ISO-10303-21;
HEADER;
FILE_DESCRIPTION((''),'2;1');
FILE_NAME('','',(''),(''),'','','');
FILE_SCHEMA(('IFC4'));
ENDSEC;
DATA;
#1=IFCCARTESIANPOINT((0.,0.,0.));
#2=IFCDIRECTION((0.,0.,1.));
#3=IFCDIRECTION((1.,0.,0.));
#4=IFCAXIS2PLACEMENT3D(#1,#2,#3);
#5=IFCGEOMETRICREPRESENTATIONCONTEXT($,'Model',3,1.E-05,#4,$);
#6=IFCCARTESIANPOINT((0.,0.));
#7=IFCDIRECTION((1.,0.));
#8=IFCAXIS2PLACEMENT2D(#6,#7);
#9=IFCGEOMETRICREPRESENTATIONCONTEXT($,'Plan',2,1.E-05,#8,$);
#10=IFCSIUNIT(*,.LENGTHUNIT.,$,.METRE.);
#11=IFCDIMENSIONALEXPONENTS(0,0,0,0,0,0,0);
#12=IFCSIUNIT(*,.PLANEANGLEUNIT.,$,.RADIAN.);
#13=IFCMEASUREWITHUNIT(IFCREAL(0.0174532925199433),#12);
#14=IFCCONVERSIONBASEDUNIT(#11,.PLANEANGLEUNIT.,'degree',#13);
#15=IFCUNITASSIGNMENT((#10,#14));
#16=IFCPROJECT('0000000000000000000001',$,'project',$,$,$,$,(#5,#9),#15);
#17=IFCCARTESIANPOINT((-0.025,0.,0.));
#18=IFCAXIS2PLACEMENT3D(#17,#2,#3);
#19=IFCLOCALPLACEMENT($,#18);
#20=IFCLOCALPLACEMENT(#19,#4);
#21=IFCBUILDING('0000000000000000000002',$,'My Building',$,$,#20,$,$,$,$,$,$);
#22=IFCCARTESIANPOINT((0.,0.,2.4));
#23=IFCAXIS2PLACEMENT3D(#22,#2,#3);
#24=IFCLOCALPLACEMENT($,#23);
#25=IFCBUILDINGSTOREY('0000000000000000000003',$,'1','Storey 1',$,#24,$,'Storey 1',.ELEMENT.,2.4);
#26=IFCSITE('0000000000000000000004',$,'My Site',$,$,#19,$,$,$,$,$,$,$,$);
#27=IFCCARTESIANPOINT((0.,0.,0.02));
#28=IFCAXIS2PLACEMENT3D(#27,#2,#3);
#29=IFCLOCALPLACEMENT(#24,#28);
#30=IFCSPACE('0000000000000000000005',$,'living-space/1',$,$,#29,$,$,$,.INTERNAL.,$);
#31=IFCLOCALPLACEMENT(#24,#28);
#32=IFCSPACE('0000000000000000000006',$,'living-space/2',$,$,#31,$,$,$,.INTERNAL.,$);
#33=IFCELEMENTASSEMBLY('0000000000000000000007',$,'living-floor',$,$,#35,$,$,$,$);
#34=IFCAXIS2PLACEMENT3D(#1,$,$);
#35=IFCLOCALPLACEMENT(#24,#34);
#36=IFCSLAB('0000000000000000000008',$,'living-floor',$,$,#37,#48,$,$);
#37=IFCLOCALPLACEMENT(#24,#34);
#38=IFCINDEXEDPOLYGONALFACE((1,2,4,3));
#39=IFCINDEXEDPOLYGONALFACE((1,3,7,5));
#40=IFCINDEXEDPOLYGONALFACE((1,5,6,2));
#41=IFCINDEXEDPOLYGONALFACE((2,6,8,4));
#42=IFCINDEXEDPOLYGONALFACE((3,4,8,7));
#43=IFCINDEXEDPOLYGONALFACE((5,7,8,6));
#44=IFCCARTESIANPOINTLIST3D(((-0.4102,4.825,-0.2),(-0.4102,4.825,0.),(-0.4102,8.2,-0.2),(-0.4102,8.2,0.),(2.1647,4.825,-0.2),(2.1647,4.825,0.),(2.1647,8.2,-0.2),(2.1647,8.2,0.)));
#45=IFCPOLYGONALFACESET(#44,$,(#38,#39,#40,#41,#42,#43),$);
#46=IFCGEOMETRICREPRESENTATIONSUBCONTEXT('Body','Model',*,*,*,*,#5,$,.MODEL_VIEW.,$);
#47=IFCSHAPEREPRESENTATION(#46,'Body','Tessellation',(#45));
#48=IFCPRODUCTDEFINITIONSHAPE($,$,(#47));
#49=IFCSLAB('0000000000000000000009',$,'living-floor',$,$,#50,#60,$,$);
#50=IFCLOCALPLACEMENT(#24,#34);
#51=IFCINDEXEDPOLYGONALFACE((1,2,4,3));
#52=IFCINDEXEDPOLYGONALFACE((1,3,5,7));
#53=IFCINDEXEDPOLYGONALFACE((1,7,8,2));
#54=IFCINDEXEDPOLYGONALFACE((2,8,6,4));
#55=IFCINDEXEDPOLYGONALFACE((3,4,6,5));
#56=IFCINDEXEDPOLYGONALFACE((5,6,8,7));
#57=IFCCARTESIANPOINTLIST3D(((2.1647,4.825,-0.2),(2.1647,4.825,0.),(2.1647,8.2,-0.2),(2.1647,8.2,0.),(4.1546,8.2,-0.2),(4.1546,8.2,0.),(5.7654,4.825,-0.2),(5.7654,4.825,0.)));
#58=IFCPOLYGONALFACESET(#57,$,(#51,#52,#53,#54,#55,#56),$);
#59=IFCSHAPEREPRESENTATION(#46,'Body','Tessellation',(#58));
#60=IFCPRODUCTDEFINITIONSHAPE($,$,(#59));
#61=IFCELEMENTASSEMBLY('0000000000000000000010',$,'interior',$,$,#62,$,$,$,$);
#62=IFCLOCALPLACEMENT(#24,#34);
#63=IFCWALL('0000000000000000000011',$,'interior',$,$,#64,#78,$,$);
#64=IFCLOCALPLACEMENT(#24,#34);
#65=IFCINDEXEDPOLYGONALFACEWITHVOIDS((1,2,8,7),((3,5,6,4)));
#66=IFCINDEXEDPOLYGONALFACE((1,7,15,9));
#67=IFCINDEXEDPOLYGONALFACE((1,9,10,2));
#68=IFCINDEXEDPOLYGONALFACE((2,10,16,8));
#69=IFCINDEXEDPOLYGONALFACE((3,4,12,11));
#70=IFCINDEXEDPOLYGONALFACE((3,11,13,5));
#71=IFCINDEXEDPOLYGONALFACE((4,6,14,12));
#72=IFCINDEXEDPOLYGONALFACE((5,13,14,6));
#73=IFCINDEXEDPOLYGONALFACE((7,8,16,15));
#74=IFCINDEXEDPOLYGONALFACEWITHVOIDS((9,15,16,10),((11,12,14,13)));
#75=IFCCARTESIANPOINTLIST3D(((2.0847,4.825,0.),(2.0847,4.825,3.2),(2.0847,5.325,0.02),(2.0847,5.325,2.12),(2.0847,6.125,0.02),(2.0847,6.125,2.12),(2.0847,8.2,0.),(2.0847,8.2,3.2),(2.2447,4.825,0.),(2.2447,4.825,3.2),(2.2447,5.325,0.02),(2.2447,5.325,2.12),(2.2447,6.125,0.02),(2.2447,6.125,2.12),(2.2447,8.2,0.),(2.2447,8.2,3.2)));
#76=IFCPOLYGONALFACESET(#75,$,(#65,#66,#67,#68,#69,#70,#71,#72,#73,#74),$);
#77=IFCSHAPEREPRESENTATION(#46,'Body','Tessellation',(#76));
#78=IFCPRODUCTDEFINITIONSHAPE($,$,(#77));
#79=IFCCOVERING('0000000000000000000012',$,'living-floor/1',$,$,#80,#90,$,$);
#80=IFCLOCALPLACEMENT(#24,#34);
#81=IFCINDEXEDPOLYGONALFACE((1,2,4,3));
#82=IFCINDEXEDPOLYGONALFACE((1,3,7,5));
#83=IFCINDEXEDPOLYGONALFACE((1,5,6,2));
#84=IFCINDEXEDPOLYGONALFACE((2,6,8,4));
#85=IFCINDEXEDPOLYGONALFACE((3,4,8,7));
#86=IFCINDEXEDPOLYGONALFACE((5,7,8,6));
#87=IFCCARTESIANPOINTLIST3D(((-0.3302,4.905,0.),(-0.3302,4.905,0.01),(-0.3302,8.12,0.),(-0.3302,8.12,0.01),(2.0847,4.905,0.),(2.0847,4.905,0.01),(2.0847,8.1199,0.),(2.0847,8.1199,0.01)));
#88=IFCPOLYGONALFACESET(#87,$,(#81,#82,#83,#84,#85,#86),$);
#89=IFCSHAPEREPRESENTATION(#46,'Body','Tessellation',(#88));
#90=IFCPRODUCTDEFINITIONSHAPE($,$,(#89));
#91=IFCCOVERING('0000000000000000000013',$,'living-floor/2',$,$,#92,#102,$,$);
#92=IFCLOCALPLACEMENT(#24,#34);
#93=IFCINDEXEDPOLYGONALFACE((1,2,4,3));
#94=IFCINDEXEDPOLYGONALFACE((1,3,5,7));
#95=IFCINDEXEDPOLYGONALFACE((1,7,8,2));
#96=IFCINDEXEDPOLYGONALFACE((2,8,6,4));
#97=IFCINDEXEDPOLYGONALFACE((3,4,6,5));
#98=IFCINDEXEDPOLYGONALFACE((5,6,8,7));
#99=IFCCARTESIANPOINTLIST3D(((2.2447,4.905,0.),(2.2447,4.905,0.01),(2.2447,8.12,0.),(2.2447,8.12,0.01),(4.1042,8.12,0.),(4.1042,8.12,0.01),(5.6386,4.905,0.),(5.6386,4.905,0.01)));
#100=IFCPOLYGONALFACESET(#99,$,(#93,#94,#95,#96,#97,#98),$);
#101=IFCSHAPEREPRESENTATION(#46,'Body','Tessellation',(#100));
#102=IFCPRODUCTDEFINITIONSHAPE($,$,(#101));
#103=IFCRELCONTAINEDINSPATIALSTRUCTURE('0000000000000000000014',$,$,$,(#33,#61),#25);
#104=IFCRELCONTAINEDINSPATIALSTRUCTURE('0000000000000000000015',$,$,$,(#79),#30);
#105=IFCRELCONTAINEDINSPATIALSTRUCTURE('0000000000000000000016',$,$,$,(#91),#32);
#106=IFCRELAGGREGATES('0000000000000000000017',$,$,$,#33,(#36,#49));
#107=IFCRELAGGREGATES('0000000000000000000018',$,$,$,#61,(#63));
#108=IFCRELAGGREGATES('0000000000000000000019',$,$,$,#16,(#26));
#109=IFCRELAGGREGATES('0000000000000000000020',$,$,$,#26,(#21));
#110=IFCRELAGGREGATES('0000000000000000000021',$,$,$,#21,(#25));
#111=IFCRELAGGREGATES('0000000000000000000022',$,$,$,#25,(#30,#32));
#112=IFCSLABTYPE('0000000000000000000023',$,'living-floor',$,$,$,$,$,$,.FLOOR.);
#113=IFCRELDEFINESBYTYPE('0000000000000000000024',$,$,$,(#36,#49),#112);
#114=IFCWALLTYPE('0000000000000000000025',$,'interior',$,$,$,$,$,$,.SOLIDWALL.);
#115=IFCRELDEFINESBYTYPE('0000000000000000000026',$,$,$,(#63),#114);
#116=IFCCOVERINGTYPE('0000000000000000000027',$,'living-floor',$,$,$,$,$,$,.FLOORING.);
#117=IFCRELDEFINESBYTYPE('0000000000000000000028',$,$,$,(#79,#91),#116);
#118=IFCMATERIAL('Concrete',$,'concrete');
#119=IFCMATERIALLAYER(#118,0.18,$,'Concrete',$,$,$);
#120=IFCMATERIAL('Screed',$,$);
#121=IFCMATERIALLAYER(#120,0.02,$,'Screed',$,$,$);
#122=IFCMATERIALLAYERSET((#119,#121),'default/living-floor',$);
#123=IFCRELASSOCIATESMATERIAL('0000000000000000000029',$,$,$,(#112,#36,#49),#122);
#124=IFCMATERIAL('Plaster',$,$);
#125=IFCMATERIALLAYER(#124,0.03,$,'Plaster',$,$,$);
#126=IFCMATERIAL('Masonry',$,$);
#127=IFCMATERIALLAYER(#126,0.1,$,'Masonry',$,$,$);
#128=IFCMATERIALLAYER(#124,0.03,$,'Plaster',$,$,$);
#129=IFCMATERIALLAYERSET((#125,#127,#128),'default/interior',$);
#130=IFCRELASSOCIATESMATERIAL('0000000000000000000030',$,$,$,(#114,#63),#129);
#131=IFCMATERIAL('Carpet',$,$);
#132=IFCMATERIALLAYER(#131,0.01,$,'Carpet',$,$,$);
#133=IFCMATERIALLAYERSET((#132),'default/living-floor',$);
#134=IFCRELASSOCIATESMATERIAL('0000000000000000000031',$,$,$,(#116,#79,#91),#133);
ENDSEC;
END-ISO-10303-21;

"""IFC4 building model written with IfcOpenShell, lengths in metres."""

from ifc_helpers import new_model, entity, si_unit, converted_unit, frame, origin, origin_with_axes, origin_2d_with_axis, place, context, subcontext, project, spatial, polyline, outline, extrude, material, layer, layer_set, layer_usage, type_object, element, aggregate, save


model = new_model("IFC4")

# Units and contexts
model_context = context("Model", 3, precision=1e-05, world=origin_with_axes())
plan_context = context("Plan", 2, precision=1e-05, world=origin_2d_with_axis())
body_context = subcontext(model_context, "Body", "Model", "MODEL_VIEW")
ifc_project = project(units=[si_unit("LENGTHUNIT", "METRE"), converted_unit("PLANEANGLEUNIT", "degree", entity("IfcReal", 0.0174532925199433), si_unit("PLANEANGLEUNIT", "RADIAN"), dimensions=[0, 0, 0, 0, 0, 0, 0])], contexts=[model_context, plan_context])

# Site, building, storey
site_placement = place(None, frame((-0.025, 0.0, 0.0), z_axis=(0.0, 0.0, 1.0), x_axis=(1.0, 0.0, 0.0)))
site = spatial("IfcSite", under=ifc_project, at=site_placement, Name="My Site")
building_placement = place(site_placement, origin_with_axes())
building = spatial("IfcBuilding", under=site, at=building_placement, Name="My Building")
storey_placement = place(None, frame((0.0, 0.0, 2.4), z_axis=(0.0, 0.0, 1.0), x_axis=(1.0, 0.0, 0.0)))
storey = spatial("IfcBuildingStorey", under=building, at=storey_placement, Name="1", Description="Storey 1", LongName="Storey 1", CompositionType="ELEMENT", Elevation=2.4)

# Element assembly, slabs
assembly_1_placement = place(storey_placement, frame((0.0, 0.0, -2.4), z_axis=(0.0, 0.0, 1.0), x_axis=(1.0, 0.0, 0.0)))
assembly_1 = element("IfcElementAssembly", 1, at=assembly_1_placement, inside=storey, Name="living-floor")
ifc_material_1 = material(Name="Concrete", Category="concrete")
ifc_layer_1 = layer(ifc_material_1, 0.18, Name="Concrete")
ifc_material_2 = material(Name="Screed")
ifc_layer_2 = layer(ifc_material_2, 0.02, Name="Screed")
ifc_layer_set_1 = layer_set([ifc_layer_1, ifc_layer_2], Name="default/living-floor")
ifc_layer_usage_1 = layer_usage(ifc_layer_set_1, "AXIS3", "POSITIVE", 0.0)
slab_type = type_object("IfcSlabType", Name="living-floor", PredefinedType="FLOOR", material=ifc_layer_set_1)
slab_1_placement = place(assembly_1_placement, frame((2.1647, 8.2, 2.2), z_axis=(0.0, 0.0, 1.0), x_axis=(1.0, 0.0, 0.0)))
slab_1 = element("IfcSlab", 2, at=slab_1_placement, type_object=slab_type, material=ifc_layer_usage_1, Name="living-floor", context=body_context, shape_type="SweptSolid", body=[
    extrude(outline(polyline([(0.0, 0.0), (-2.5749, 0.0), (-2.5749, -3.375), (0.0, -3.375), (0.0, 0.0)])), origin(), (0.0, 0.0, 1.0), 0.2),
])
ifc_layer_usage_2 = layer_usage(ifc_layer_set_1, "AXIS3", "POSITIVE", 0.0)
slab_2_placement = place(assembly_1_placement, frame((2.1647, 8.2, 2.2), z_axis=(0.0, 0.0, 1.0), x_axis=(1.0, 0.0, 0.0)))
slab_2 = element("IfcSlab", 3, at=slab_2_placement, type_object=slab_type, material=ifc_layer_usage_2, Name="living-floor", context=body_context, shape_type="SweptSolid", body=[
    extrude(outline(polyline([(0.0, 0.0), (0.0, -3.375), (3.6007, -3.375), (1.99, 0.0), (0.0, 0.0)])), origin(), (0.0, 0.0, 1.0), 0.2),
])
aggregate(assembly_1, [slab_1, slab_2])

# Element assembly, wall, opening
assembly_2_placement = place(storey_placement, frame((2.1647, 4.825, 0.0), z_axis=(0.0, 0.0, 1.0), x_axis=(0.0, 1.0, 0.0)))
assembly_2 = element("IfcElementAssembly", 4, at=assembly_2_placement, inside=storey, Name="interior")
ifc_material_3 = material(Name="Plaster")
ifc_layer_3 = layer(ifc_material_3, 0.03, Name="Plaster")
ifc_material_4 = material(Name="Masonry")
ifc_layer_4 = layer(ifc_material_4, 0.1, Name="Masonry")
ifc_layer_5 = layer(ifc_material_3, 0.03, Name="Plaster")
ifc_layer_set_2 = layer_set([ifc_layer_3, ifc_layer_4, ifc_layer_5], Name="default/interior")
ifc_layer_usage_3 = layer_usage(ifc_layer_set_2, "AXIS2", "POSITIVE", -0.08)
wall_type_1 = type_object("IfcWallType", Name="interior", PredefinedType="SOLIDWALL", material=ifc_layer_set_2)
wall_1_placement = place(assembly_2_placement, origin_with_axes())
wall_1 = element("IfcWall", 5, at=wall_1_placement, type_object=wall_type_1, material=ifc_layer_usage_3, Name="interior", context=body_context, shape_type="SweptSolid", body=[
    extrude(outline(polyline([(0.0, 0.08), (0.0, -0.08), (3.375, -0.08), (3.375, 0.08), (0.0, 0.08)])), origin(), (0.0, 0.0, 1.0), 3.2),
])
opening_placement = place(wall_1_placement, frame((0.5, -0.08, 0.02), z_axis=(0.0, 0.0, 1.0), x_axis=(1.0, 0.0, 0.0)))
element("IfcOpeningElement", 6, at=opening_placement, cuts=wall_1, PredefinedType="OPENING", context=body_context, shape_type="SweptSolid", body=[
    extrude(outline(polyline([(0.0, 0.0), (0.8, 0.0), (0.8, 2.1), (0.0, 2.1), (0.0, 0.0)])), frame((0.0, -0.02, 0.0), z_axis=(0.0, -1.0, 0.0), x_axis=(1.0, 0.0, 0.0)), (0.0, 0.0, -1.0), 0.2),
])
aggregate(assembly_2, [wall_1])

# Shared definitions
space_1_placement = place(storey_placement, frame((0.0, 0.0, 0.02), z_axis=(0.0, 0.0, 1.0), x_axis=(1.0, 0.0, 0.0)))
space_1 = spatial("IfcSpace", under=storey, at=space_1_placement, Name="living-space/1", PredefinedType="INTERNAL")

# Covering
ifc_material_5 = material(Name="Carpet")
ifc_layer_6 = layer(ifc_material_5, 0.01, Name="Carpet")
ifc_layer_set_3 = layer_set([ifc_layer_6], Name="default/living-floor")
ifc_layer_usage_4 = layer_usage(ifc_layer_set_3, "AXIS2", "POSITIVE", 0.0)
covering_type = type_object("IfcCoveringType", Name="living-floor", PredefinedType="FLOORING", material=ifc_layer_set_3)
covering_1_placement = place(space_1_placement, frame((0.0, 0.0, -0.02), z_axis=(0.0, 0.0, 1.0), x_axis=(1.0, 0.0, 0.0)))
element("IfcCovering", 7, at=covering_1_placement, inside=space_1, type_object=covering_type, material=ifc_layer_usage_4, Name="living-floor/1", context=body_context, shape_type="SweptSolid", body=[
    extrude(outline(polyline([(-0.3302, 4.905), (2.0847, 4.905), (2.0847, 8.1199), (-0.3302, 8.12), (-0.3302, 4.905)])), origin_with_axes(), (0.0, 0.0, 1.0), 0.01),
])

# Shared definitions
space_2_placement = place(storey_placement, frame((0.0, 0.0, 0.02), z_axis=(0.0, 0.0, 1.0), x_axis=(1.0, 0.0, 0.0)))
space_2 = spatial("IfcSpace", under=storey, at=space_2_placement, Name="living-space/2", PredefinedType="INTERNAL")

# Covering
ifc_layer_usage_5 = layer_usage(ifc_layer_set_3, "AXIS2", "POSITIVE", 0.0)
covering_2_placement = place(space_2_placement, frame((0.0, 0.0, -0.02), z_axis=(0.0, 0.0, 1.0), x_axis=(1.0, 0.0, 0.0)))
element("IfcCovering", 8, at=covering_2_placement, inside=space_2, type_object=covering_type, material=ifc_layer_usage_5, Name="living-floor/2", context=body_context, shape_type="SweptSolid", body=[
    extrude(outline(polyline([(5.6386, 4.905), (4.1042, 8.12), (2.2447, 8.12), (2.2447, 4.905), (5.6386, 4.905)])), origin_with_axes(), (0.0, 0.0, 1.0), 0.01),
])

save(model, "model.ifc")
